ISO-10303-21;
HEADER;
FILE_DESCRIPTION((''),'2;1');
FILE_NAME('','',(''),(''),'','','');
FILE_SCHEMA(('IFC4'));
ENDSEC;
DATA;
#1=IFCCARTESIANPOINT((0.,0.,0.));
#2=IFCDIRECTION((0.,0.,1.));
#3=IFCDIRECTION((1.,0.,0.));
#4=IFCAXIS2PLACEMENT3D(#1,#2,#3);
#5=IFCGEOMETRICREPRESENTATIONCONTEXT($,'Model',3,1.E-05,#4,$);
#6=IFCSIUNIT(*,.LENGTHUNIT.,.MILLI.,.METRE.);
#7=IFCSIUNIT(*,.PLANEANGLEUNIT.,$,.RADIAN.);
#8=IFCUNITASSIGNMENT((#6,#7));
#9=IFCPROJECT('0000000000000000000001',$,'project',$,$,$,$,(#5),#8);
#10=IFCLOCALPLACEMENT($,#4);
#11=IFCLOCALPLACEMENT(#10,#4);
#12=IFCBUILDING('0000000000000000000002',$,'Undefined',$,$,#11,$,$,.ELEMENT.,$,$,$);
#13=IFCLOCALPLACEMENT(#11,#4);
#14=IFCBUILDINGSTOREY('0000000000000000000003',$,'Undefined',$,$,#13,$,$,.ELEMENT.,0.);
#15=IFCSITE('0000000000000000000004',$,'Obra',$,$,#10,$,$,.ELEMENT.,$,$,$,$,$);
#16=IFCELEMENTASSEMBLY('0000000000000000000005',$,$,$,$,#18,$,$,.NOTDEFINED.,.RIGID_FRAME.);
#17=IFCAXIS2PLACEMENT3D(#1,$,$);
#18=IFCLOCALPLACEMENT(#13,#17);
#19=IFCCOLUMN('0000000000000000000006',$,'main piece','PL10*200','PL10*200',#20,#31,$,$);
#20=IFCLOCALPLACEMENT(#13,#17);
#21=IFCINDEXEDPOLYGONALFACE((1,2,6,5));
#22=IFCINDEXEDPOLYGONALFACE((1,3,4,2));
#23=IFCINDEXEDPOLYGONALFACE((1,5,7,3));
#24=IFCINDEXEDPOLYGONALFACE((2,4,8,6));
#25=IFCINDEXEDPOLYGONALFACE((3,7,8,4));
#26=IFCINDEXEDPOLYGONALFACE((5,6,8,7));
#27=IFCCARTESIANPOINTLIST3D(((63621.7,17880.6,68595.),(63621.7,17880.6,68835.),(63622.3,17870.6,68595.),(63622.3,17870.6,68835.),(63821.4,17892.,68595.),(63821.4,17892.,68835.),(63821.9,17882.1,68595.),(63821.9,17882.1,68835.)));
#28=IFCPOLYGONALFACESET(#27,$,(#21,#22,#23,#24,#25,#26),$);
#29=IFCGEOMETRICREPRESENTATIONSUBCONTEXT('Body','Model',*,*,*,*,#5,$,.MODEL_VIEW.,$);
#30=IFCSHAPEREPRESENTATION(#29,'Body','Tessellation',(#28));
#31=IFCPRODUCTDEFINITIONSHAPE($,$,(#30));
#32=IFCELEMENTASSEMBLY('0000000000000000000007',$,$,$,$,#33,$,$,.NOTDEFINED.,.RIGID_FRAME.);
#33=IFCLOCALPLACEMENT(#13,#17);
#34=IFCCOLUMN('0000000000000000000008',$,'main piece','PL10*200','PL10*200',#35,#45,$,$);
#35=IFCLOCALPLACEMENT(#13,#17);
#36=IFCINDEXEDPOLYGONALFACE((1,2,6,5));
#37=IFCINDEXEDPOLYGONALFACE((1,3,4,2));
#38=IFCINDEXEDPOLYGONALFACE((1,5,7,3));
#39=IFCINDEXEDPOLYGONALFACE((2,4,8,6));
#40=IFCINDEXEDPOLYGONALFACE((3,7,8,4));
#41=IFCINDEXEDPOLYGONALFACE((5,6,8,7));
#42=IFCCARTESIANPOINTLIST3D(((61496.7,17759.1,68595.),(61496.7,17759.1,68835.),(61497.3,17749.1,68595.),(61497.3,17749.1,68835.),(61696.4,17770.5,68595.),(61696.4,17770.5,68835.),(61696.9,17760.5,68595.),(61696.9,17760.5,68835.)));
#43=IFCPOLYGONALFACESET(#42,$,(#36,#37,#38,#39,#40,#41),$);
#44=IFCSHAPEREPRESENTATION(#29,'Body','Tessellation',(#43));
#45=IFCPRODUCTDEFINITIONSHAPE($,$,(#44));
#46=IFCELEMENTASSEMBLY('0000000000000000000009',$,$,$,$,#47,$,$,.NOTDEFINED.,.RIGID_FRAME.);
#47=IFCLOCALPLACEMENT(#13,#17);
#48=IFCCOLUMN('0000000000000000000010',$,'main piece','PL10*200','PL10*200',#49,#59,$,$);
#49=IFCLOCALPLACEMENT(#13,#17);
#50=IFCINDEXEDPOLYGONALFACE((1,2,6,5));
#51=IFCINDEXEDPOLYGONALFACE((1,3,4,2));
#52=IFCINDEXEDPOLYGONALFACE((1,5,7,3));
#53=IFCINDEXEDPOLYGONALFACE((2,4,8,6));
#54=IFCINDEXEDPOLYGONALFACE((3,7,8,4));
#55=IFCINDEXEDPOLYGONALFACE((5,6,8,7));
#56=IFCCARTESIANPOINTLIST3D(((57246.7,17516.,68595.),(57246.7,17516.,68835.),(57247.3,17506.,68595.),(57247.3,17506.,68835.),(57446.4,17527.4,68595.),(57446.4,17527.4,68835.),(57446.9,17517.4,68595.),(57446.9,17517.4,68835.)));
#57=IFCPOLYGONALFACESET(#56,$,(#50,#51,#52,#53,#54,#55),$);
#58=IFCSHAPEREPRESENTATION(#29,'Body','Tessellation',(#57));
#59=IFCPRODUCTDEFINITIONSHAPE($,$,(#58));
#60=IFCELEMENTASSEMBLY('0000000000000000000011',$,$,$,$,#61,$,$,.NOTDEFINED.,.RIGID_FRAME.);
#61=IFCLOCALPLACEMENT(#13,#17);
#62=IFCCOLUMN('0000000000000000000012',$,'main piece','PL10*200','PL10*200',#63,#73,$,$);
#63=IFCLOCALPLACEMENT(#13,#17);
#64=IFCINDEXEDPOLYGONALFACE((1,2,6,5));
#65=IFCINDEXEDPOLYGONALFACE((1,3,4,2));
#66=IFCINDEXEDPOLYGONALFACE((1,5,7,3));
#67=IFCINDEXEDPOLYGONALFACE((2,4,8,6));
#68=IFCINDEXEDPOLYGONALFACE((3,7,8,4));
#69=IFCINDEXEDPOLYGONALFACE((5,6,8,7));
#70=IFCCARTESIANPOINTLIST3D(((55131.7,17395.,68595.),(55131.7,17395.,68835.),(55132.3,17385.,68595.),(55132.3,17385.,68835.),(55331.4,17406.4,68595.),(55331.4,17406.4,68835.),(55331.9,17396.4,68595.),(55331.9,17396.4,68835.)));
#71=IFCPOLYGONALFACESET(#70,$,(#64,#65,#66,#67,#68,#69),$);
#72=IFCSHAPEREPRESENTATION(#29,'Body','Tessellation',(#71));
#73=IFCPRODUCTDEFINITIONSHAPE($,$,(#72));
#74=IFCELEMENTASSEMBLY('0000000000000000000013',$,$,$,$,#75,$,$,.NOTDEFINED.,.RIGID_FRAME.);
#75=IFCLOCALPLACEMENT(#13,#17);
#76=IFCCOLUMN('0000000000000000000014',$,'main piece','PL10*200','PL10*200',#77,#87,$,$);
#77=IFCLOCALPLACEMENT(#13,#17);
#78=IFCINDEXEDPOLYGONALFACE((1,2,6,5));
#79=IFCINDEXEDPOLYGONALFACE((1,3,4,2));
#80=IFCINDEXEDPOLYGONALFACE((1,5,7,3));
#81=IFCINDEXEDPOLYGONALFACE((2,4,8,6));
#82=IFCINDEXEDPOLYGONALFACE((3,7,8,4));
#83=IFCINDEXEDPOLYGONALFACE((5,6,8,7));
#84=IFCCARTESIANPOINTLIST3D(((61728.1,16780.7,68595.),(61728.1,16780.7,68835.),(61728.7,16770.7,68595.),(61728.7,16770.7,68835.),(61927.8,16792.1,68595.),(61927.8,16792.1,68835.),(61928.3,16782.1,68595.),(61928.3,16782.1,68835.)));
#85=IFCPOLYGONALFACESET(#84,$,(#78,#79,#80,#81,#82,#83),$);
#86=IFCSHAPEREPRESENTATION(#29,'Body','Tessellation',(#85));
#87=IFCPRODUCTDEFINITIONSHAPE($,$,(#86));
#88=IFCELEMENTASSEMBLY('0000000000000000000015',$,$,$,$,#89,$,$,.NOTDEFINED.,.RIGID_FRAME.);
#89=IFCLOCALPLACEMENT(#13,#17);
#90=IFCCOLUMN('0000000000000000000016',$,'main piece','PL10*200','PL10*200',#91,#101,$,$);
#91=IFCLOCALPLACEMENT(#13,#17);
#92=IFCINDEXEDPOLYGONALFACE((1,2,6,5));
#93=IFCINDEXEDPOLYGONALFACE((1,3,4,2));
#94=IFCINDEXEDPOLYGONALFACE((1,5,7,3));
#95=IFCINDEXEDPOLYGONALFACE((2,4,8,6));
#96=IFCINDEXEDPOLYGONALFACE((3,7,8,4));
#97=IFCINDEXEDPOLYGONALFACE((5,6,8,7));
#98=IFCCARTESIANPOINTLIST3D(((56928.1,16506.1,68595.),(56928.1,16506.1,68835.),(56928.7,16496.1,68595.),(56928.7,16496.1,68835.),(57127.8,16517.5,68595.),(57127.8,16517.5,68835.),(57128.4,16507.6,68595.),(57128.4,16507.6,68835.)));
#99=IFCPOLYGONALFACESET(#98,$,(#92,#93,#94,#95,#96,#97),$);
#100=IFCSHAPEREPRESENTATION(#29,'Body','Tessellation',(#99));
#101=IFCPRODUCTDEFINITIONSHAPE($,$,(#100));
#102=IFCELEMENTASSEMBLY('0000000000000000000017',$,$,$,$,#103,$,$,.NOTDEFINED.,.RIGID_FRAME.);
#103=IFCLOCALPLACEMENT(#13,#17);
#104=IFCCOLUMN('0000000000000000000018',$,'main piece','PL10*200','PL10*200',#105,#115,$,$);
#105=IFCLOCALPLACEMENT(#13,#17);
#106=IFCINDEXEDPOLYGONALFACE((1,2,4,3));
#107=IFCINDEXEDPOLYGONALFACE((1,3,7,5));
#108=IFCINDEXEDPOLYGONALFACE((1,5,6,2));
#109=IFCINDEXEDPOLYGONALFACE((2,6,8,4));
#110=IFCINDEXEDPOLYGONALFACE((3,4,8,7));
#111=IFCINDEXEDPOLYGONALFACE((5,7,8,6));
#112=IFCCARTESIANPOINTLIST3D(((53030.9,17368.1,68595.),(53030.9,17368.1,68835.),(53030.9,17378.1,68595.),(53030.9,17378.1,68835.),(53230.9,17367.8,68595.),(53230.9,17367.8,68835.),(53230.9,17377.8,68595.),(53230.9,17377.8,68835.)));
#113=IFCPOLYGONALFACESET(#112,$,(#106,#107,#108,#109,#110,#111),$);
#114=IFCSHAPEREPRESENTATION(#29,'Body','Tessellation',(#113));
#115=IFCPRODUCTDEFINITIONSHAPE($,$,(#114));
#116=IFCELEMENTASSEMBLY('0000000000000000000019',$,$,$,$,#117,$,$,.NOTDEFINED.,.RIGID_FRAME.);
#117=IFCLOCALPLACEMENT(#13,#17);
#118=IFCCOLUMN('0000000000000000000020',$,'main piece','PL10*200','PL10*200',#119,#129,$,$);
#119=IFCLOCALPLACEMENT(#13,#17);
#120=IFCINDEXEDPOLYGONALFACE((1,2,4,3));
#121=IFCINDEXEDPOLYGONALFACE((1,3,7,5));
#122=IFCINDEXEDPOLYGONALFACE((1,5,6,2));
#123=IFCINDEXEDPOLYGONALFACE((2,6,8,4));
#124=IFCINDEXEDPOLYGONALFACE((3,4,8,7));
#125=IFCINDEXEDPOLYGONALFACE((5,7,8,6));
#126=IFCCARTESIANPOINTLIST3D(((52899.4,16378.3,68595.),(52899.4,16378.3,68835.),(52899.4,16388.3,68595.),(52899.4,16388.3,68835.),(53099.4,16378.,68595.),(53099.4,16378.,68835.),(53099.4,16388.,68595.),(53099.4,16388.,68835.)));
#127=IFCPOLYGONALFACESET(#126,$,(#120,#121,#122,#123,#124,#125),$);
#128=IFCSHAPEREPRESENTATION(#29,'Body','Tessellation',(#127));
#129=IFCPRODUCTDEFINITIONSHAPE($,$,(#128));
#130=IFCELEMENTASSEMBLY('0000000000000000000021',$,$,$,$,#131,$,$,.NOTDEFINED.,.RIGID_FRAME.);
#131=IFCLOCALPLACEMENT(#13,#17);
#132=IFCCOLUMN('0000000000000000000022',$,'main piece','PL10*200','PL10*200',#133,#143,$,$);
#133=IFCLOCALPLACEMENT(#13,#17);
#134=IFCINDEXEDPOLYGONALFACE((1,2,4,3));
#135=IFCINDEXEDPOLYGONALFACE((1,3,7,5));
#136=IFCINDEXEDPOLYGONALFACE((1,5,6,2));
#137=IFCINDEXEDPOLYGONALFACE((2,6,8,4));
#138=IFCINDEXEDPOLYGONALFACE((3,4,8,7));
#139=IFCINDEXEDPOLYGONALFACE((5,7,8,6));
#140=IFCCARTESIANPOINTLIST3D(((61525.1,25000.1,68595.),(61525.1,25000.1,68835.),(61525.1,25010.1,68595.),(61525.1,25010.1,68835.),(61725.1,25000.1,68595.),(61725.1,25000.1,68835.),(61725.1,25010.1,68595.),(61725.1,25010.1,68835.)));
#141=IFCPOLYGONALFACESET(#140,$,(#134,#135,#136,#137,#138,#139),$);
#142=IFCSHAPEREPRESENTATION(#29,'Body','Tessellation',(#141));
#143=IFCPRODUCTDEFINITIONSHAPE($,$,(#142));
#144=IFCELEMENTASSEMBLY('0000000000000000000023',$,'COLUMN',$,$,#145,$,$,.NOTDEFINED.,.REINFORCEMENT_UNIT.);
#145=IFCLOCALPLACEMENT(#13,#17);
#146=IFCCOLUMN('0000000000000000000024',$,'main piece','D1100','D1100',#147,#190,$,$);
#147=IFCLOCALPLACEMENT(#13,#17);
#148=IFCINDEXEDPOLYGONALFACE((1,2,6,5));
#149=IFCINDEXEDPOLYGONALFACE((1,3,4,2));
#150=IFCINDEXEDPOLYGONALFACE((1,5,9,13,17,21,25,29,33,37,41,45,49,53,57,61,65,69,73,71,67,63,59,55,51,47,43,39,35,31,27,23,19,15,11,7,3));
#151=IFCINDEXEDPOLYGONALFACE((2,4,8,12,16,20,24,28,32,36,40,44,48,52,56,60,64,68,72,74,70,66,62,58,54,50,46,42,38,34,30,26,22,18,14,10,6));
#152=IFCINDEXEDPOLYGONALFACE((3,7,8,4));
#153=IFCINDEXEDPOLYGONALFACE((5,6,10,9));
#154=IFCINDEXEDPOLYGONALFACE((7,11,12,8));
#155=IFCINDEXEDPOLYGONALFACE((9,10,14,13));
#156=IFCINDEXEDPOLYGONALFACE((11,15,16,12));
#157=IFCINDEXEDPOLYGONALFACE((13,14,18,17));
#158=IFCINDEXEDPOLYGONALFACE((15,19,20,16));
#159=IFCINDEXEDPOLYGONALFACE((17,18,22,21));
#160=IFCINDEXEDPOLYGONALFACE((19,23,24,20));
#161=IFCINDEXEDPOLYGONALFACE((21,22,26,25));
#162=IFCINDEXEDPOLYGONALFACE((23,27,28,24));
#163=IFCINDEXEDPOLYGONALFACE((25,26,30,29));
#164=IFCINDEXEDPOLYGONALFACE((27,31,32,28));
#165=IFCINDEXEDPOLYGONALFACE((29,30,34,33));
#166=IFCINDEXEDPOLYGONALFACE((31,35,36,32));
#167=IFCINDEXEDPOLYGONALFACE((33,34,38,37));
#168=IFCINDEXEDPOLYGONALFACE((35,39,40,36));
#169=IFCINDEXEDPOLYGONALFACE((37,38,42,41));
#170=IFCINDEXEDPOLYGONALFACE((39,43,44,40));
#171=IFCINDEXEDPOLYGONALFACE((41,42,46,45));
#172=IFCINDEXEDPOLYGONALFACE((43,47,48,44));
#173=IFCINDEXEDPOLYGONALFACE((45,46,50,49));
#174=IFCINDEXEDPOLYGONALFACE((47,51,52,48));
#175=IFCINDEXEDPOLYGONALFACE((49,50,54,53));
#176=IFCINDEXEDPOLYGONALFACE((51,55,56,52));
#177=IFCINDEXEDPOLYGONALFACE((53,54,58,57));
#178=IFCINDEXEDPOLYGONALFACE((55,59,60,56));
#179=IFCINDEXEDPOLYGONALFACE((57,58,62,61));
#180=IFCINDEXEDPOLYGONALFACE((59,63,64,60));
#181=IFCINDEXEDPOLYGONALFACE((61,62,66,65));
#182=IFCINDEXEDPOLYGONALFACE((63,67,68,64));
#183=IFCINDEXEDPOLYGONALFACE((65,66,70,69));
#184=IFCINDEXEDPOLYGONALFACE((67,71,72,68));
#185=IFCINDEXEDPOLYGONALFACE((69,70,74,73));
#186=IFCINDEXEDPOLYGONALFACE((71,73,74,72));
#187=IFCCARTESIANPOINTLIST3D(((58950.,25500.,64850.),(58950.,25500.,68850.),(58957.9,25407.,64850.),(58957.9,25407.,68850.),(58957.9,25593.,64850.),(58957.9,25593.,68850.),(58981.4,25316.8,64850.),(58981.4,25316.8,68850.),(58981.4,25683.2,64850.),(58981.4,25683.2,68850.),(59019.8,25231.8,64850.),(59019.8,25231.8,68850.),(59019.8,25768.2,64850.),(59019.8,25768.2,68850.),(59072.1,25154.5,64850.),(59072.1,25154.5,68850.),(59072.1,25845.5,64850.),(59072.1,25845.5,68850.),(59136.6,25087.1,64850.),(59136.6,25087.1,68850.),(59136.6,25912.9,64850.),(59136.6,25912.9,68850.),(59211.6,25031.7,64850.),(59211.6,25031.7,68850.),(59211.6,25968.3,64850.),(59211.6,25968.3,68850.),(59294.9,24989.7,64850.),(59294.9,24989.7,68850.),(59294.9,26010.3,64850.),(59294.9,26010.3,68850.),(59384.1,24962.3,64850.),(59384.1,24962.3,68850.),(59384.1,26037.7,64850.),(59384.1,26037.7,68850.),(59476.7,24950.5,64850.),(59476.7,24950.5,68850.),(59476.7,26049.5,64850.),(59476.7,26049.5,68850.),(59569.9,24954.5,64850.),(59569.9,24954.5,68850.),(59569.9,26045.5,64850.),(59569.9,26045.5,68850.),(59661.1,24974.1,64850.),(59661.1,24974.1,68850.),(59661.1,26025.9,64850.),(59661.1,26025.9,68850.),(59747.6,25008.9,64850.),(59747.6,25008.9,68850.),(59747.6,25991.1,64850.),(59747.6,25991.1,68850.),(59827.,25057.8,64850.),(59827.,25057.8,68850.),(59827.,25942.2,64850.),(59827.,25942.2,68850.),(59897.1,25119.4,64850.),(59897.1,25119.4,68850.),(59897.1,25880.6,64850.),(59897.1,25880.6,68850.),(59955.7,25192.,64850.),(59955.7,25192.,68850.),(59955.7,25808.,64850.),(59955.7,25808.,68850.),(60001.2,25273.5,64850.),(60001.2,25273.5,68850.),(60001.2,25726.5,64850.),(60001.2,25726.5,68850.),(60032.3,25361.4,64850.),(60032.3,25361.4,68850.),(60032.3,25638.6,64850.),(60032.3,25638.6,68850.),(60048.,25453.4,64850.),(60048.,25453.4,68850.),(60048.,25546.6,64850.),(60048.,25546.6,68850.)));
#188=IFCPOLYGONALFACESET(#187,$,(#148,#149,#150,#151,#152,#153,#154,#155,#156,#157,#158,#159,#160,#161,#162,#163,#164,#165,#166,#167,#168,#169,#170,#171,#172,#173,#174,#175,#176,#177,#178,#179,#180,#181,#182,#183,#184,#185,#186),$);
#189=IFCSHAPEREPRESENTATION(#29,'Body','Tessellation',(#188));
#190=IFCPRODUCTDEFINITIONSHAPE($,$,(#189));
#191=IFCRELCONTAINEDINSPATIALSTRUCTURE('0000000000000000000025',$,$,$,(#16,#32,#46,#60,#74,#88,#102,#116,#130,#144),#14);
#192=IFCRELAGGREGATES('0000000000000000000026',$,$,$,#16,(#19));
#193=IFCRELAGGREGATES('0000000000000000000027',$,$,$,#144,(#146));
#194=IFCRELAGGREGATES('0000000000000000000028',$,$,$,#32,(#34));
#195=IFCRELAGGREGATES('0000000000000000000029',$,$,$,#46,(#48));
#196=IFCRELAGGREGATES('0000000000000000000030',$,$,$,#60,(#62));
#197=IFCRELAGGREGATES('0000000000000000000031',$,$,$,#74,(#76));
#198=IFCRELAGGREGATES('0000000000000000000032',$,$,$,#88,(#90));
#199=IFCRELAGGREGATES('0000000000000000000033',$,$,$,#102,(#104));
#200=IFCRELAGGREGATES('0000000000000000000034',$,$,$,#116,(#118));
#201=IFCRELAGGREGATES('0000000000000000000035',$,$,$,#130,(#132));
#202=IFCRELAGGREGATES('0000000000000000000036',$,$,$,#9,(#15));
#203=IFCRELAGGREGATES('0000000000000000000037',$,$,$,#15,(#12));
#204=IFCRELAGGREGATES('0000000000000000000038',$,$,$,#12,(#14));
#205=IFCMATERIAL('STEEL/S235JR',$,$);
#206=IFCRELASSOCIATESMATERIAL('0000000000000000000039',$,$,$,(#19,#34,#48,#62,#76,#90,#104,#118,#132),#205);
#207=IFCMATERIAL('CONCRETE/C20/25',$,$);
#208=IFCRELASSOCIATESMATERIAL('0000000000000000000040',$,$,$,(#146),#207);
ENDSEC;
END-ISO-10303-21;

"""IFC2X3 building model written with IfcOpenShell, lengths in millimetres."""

from ifc_helpers import new_model, si_unit, frame, origin_with_axes, origin_2d_with_axis, place, context, subcontext, project, spatial, rectangle, circle, extrude, material, element, aggregate, save


model = new_model("IFC2X3")

# Units and contexts
model_context = context("Model", 3, precision=1e-05, world=origin_with_axes())
body_context = subcontext(model_context, "Body", "Model", "MODEL_VIEW")
ifc_project = project(units=[si_unit("LENGTHUNIT", "METRE", prefix="MILLI"), si_unit("PLANEANGLEUNIT", "RADIAN")], contexts=[model_context])

# Site, building, storey
site_placement = place(None, origin_with_axes())
site = spatial("IfcSite", under=ifc_project, at=site_placement, Name="Obra", CompositionType="ELEMENT")
building_placement = place(site_placement, origin_with_axes())
building = spatial("IfcBuilding", under=site, at=building_placement, Name="Undefined", CompositionType="ELEMENT")
storey_placement = place(building_placement, origin_with_axes())
storey = spatial("IfcBuildingStorey", under=building, at=storey_placement, Name="Undefined", CompositionType="ELEMENT", Elevation=0.0)

# Element assemblies, columns
assembly_1_placement = place(storey_placement, origin_with_axes())
assembly_1 = element("IfcElementAssembly", 1, at=assembly_1_placement, inside=storey, AssemblyPlace="NOTDEFINED", PredefinedType="RIGID_FRAME")
ifc_material_1 = material(Name="STEEL/S235JR")
column_1_placement = place(assembly_1_placement, frame((63721.8, 17881.3, 68595.0), z_axis=(0.0, 0.0, 1.0), x_axis=(0.998368, 0.057107, 0.0)))
column_1 = element("IfcColumn", 2, at=column_1_placement, material=ifc_material_1, Name="main piece", Description="PL10*200", ObjectType="PL10*200", context=body_context, shape_type="SweptSolid", body=[
    extrude(rectangle(XDim=10.0, YDim=200.0, at=origin_2d_with_axis()), frame((0.0, 0.0, 240.0), z_axis=(0.0, 0.0, -1.0), x_axis=(0.0, 1.0, 0.0)), (0.0, 0.0, 1.0), 240.0),
])
aggregate(assembly_1, [column_1])
assembly_2_placement = place(storey_placement, origin_with_axes())
assembly_2 = element("IfcElementAssembly", 3, at=assembly_2_placement, inside=storey, AssemblyPlace="NOTDEFINED", PredefinedType="RIGID_FRAME")
column_2_placement = place(assembly_2_placement, frame((61596.8, 17759.8, 68595.0), z_axis=(0.0, 0.0, 1.0), x_axis=(0.998368, 0.057107, 0.0)))
column_2 = element("IfcColumn", 4, at=column_2_placement, material=ifc_material_1, Name="main piece", Description="PL10*200", ObjectType="PL10*200", context=body_context, shape_type="SweptSolid", body=[
    extrude(rectangle(XDim=10.0, YDim=200.0, at=origin_2d_with_axis()), frame((0.0, 0.0, 240.0), z_axis=(0.0, 0.0, -1.0), x_axis=(0.0, 1.0, 0.0)), (0.0, 0.0, 1.0), 240.0),
])
assembly_3_placement = place(storey_placement, origin_with_axes())
assembly_3 = element("IfcElementAssembly", 5, at=assembly_3_placement, inside=storey, AssemblyPlace="NOTDEFINED", PredefinedType="RIGID_FRAME")
column_3_placement = place(assembly_3_placement, frame((57346.8, 17516.7, 68595.0), z_axis=(0.0, 0.0, 1.0), x_axis=(0.998368, 0.057107, 0.0)))
column_3 = element("IfcColumn", 6, at=column_3_placement, material=ifc_material_1, Name="main piece", Description="PL10*200", ObjectType="PL10*200", context=body_context, shape_type="SweptSolid", body=[
    extrude(rectangle(XDim=10.0, YDim=200.0, at=origin_2d_with_axis()), frame((0.0, 0.0, 240.0), z_axis=(0.0, 0.0, -1.0), x_axis=(0.0, 1.0, 0.0)), (0.0, 0.0, 1.0), 240.0),
])
assembly_4_placement = place(storey_placement, origin_with_axes())
assembly_4 = element("IfcElementAssembly", 7, at=assembly_4_placement, inside=storey, AssemblyPlace="NOTDEFINED", PredefinedType="RIGID_FRAME")
column_4_placement = place(assembly_4_placement, frame((55231.8, 17395.7, 68595.0), z_axis=(0.0, 0.0, 1.0), x_axis=(0.998368, 0.057107, 0.0)))
column_4 = element("IfcColumn", 8, at=column_4_placement, material=ifc_material_1, Name="main piece", Description="PL10*200", ObjectType="PL10*200", context=body_context, shape_type="SweptSolid", body=[
    extrude(rectangle(XDim=10.0, YDim=200.0, at=origin_2d_with_axis()), frame((0.0, 0.0, 240.0), z_axis=(0.0, 0.0, -1.0), x_axis=(0.0, 1.0, 0.0)), (0.0, 0.0, 1.0), 240.0),
])
assembly_5_placement = place(storey_placement, origin_with_axes())
assembly_5 = element("IfcElementAssembly", 9, at=assembly_5_placement, inside=storey, AssemblyPlace="NOTDEFINED", PredefinedType="RIGID_FRAME")
column_5_placement = place(assembly_5_placement, frame((61828.2, 16781.4, 68595.0), z_axis=(0.0, 0.0, 1.0), x_axis=(-0.998368, -0.057107, 0.0)))
column_5 = element("IfcColumn", 10, at=column_5_placement, material=ifc_material_1, Name="main piece", Description="PL10*200", ObjectType="PL10*200", context=body_context, shape_type="SweptSolid", body=[
    extrude(rectangle(XDim=10.0, YDim=200.0, at=origin_2d_with_axis()), frame((0.0, 0.0, 240.0), z_axis=(0.0, 0.0, -1.0), x_axis=(0.0, 1.0, 0.0)), (0.0, 0.0, 1.0), 240.0),
])
assembly_6_placement = place(storey_placement, origin_with_axes())
assembly_6 = element("IfcElementAssembly", 11, at=assembly_6_placement, inside=storey, AssemblyPlace="NOTDEFINED", PredefinedType="RIGID_FRAME")
column_6_placement = place(assembly_6_placement, frame((57028.3, 16506.8, 68595.0), z_axis=(0.0, 0.0, 1.0), x_axis=(-0.998368, -0.057107, 0.0)))
column_6 = element("IfcColumn", 12, at=column_6_placement, material=ifc_material_1, Name="main piece", Description="PL10*200", ObjectType="PL10*200", context=body_context, shape_type="SweptSolid", body=[
    extrude(rectangle(XDim=10.0, YDim=200.0, at=origin_2d_with_axis()), frame((0.0, 0.0, 240.0), z_axis=(0.0, 0.0, -1.0), x_axis=(0.0, 1.0, 0.0)), (0.0, 0.0, 1.0), 240.0),
])
assembly_7_placement = place(storey_placement, origin_with_axes())
assembly_7 = element("IfcElementAssembly", 13, at=assembly_7_placement, inside=storey, AssemblyPlace="NOTDEFINED", PredefinedType="RIGID_FRAME")
column_7_placement = place(assembly_7_placement, frame((53130.9, 17373.0, 68595.0), z_axis=(0.0, 0.0, 1.0), x_axis=(0.999999, -0.001649, 0.0)))
column_7 = element("IfcColumn", 14, at=column_7_placement, material=ifc_material_1, Name="main piece", Description="PL10*200", ObjectType="PL10*200", context=body_context, shape_type="SweptSolid", body=[
    extrude(rectangle(XDim=10.0, YDim=200.0, at=origin_2d_with_axis()), frame((0.0, 0.0, 240.0), z_axis=(0.0, 0.0, -1.0), x_axis=(0.0, 1.0, 0.0)), (0.0, 0.0, 1.0), 240.0),
])
assembly_8_placement = place(storey_placement, origin_with_axes())
assembly_8 = element("IfcElementAssembly", 15, at=assembly_8_placement, inside=storey, AssemblyPlace="NOTDEFINED", PredefinedType="RIGID_FRAME")
column_8_placement = place(assembly_8_placement, frame((52999.4, 16383.2, 68595.0), z_axis=(0.0, 0.0, 1.0), x_axis=(-0.999999, 0.001649, 0.0)))
column_8 = element("IfcColumn", 16, at=column_8_placement, material=ifc_material_1, Name="main piece", Description="PL10*200", ObjectType="PL10*200", context=body_context, shape_type="SweptSolid", body=[
    extrude(rectangle(XDim=10.0, YDim=200.0, at=origin_2d_with_axis()), frame((0.0, 0.0, 240.0), z_axis=(0.0, 0.0, -1.0), x_axis=(0.0, 1.0, 0.0)), (0.0, 0.0, 1.0), 240.0),
])
assembly_9_placement = place(storey_placement, origin_with_axes())
assembly_9 = element("IfcElementAssembly", 17, at=assembly_9_placement, inside=storey, AssemblyPlace="NOTDEFINED", PredefinedType="RIGID_FRAME")
column_9_placement = place(assembly_9_placement, frame((61625.1, 25005.1, 68595.0), z_axis=(0.0, 0.0, 1.0), x_axis=(-1.0, -0.000002, 0.0)))
column_9 = element("IfcColumn", 18, at=column_9_placement, material=ifc_material_1, Name="main piece", Description="PL10*200", ObjectType="PL10*200", context=body_context, shape_type="SweptSolid", body=[
    extrude(rectangle(XDim=10.0, YDim=200.0, at=origin_2d_with_axis()), frame((0.0, 0.0, 240.0), z_axis=(0.0, 0.0, -1.0), x_axis=(0.0, 1.0, 0.0)), (0.0, 0.0, 1.0), 240.0),
])
assembly_10_placement = place(storey_placement, origin_with_axes())
assembly_10 = element("IfcElementAssembly", 19, at=assembly_10_placement, inside=storey, Name="COLUMN", AssemblyPlace="NOTDEFINED", PredefinedType="REINFORCEMENT_UNIT")
ifc_material_2 = material(Name="CONCRETE/C20/25")
column_10_placement = place(assembly_10_placement, frame((59500.0, 25500.0, 64850.0), z_axis=(0.0, 0.0, 1.0), x_axis=(0.0, 1.0, 0.0)))
column_10 = element("IfcColumn", 20, at=column_10_placement, material=ifc_material_2, Name="main piece", Description="D1100", ObjectType="D1100", context=body_context, shape_type="SweptSolid", body=[
    extrude(circle(Radius=550.0, at=origin_2d_with_axis()), frame((0.0, 0.0, 4000.0), z_axis=(0.0, 0.0, -1.0), x_axis=(0.0, 1.0, 0.0)), (0.0, 0.0, 1.0), 4000.0),
])
aggregate(assembly_10, [column_10])

aggregate(assembly_2, [column_2])
aggregate(assembly_3, [column_3])
aggregate(assembly_4, [column_4])
aggregate(assembly_5, [column_5])
aggregate(assembly_6, [column_6])
aggregate(assembly_7, [column_7])
aggregate(assembly_8, [column_8])
aggregate(assembly_9, [column_9])

save(model, "model.ifc")
